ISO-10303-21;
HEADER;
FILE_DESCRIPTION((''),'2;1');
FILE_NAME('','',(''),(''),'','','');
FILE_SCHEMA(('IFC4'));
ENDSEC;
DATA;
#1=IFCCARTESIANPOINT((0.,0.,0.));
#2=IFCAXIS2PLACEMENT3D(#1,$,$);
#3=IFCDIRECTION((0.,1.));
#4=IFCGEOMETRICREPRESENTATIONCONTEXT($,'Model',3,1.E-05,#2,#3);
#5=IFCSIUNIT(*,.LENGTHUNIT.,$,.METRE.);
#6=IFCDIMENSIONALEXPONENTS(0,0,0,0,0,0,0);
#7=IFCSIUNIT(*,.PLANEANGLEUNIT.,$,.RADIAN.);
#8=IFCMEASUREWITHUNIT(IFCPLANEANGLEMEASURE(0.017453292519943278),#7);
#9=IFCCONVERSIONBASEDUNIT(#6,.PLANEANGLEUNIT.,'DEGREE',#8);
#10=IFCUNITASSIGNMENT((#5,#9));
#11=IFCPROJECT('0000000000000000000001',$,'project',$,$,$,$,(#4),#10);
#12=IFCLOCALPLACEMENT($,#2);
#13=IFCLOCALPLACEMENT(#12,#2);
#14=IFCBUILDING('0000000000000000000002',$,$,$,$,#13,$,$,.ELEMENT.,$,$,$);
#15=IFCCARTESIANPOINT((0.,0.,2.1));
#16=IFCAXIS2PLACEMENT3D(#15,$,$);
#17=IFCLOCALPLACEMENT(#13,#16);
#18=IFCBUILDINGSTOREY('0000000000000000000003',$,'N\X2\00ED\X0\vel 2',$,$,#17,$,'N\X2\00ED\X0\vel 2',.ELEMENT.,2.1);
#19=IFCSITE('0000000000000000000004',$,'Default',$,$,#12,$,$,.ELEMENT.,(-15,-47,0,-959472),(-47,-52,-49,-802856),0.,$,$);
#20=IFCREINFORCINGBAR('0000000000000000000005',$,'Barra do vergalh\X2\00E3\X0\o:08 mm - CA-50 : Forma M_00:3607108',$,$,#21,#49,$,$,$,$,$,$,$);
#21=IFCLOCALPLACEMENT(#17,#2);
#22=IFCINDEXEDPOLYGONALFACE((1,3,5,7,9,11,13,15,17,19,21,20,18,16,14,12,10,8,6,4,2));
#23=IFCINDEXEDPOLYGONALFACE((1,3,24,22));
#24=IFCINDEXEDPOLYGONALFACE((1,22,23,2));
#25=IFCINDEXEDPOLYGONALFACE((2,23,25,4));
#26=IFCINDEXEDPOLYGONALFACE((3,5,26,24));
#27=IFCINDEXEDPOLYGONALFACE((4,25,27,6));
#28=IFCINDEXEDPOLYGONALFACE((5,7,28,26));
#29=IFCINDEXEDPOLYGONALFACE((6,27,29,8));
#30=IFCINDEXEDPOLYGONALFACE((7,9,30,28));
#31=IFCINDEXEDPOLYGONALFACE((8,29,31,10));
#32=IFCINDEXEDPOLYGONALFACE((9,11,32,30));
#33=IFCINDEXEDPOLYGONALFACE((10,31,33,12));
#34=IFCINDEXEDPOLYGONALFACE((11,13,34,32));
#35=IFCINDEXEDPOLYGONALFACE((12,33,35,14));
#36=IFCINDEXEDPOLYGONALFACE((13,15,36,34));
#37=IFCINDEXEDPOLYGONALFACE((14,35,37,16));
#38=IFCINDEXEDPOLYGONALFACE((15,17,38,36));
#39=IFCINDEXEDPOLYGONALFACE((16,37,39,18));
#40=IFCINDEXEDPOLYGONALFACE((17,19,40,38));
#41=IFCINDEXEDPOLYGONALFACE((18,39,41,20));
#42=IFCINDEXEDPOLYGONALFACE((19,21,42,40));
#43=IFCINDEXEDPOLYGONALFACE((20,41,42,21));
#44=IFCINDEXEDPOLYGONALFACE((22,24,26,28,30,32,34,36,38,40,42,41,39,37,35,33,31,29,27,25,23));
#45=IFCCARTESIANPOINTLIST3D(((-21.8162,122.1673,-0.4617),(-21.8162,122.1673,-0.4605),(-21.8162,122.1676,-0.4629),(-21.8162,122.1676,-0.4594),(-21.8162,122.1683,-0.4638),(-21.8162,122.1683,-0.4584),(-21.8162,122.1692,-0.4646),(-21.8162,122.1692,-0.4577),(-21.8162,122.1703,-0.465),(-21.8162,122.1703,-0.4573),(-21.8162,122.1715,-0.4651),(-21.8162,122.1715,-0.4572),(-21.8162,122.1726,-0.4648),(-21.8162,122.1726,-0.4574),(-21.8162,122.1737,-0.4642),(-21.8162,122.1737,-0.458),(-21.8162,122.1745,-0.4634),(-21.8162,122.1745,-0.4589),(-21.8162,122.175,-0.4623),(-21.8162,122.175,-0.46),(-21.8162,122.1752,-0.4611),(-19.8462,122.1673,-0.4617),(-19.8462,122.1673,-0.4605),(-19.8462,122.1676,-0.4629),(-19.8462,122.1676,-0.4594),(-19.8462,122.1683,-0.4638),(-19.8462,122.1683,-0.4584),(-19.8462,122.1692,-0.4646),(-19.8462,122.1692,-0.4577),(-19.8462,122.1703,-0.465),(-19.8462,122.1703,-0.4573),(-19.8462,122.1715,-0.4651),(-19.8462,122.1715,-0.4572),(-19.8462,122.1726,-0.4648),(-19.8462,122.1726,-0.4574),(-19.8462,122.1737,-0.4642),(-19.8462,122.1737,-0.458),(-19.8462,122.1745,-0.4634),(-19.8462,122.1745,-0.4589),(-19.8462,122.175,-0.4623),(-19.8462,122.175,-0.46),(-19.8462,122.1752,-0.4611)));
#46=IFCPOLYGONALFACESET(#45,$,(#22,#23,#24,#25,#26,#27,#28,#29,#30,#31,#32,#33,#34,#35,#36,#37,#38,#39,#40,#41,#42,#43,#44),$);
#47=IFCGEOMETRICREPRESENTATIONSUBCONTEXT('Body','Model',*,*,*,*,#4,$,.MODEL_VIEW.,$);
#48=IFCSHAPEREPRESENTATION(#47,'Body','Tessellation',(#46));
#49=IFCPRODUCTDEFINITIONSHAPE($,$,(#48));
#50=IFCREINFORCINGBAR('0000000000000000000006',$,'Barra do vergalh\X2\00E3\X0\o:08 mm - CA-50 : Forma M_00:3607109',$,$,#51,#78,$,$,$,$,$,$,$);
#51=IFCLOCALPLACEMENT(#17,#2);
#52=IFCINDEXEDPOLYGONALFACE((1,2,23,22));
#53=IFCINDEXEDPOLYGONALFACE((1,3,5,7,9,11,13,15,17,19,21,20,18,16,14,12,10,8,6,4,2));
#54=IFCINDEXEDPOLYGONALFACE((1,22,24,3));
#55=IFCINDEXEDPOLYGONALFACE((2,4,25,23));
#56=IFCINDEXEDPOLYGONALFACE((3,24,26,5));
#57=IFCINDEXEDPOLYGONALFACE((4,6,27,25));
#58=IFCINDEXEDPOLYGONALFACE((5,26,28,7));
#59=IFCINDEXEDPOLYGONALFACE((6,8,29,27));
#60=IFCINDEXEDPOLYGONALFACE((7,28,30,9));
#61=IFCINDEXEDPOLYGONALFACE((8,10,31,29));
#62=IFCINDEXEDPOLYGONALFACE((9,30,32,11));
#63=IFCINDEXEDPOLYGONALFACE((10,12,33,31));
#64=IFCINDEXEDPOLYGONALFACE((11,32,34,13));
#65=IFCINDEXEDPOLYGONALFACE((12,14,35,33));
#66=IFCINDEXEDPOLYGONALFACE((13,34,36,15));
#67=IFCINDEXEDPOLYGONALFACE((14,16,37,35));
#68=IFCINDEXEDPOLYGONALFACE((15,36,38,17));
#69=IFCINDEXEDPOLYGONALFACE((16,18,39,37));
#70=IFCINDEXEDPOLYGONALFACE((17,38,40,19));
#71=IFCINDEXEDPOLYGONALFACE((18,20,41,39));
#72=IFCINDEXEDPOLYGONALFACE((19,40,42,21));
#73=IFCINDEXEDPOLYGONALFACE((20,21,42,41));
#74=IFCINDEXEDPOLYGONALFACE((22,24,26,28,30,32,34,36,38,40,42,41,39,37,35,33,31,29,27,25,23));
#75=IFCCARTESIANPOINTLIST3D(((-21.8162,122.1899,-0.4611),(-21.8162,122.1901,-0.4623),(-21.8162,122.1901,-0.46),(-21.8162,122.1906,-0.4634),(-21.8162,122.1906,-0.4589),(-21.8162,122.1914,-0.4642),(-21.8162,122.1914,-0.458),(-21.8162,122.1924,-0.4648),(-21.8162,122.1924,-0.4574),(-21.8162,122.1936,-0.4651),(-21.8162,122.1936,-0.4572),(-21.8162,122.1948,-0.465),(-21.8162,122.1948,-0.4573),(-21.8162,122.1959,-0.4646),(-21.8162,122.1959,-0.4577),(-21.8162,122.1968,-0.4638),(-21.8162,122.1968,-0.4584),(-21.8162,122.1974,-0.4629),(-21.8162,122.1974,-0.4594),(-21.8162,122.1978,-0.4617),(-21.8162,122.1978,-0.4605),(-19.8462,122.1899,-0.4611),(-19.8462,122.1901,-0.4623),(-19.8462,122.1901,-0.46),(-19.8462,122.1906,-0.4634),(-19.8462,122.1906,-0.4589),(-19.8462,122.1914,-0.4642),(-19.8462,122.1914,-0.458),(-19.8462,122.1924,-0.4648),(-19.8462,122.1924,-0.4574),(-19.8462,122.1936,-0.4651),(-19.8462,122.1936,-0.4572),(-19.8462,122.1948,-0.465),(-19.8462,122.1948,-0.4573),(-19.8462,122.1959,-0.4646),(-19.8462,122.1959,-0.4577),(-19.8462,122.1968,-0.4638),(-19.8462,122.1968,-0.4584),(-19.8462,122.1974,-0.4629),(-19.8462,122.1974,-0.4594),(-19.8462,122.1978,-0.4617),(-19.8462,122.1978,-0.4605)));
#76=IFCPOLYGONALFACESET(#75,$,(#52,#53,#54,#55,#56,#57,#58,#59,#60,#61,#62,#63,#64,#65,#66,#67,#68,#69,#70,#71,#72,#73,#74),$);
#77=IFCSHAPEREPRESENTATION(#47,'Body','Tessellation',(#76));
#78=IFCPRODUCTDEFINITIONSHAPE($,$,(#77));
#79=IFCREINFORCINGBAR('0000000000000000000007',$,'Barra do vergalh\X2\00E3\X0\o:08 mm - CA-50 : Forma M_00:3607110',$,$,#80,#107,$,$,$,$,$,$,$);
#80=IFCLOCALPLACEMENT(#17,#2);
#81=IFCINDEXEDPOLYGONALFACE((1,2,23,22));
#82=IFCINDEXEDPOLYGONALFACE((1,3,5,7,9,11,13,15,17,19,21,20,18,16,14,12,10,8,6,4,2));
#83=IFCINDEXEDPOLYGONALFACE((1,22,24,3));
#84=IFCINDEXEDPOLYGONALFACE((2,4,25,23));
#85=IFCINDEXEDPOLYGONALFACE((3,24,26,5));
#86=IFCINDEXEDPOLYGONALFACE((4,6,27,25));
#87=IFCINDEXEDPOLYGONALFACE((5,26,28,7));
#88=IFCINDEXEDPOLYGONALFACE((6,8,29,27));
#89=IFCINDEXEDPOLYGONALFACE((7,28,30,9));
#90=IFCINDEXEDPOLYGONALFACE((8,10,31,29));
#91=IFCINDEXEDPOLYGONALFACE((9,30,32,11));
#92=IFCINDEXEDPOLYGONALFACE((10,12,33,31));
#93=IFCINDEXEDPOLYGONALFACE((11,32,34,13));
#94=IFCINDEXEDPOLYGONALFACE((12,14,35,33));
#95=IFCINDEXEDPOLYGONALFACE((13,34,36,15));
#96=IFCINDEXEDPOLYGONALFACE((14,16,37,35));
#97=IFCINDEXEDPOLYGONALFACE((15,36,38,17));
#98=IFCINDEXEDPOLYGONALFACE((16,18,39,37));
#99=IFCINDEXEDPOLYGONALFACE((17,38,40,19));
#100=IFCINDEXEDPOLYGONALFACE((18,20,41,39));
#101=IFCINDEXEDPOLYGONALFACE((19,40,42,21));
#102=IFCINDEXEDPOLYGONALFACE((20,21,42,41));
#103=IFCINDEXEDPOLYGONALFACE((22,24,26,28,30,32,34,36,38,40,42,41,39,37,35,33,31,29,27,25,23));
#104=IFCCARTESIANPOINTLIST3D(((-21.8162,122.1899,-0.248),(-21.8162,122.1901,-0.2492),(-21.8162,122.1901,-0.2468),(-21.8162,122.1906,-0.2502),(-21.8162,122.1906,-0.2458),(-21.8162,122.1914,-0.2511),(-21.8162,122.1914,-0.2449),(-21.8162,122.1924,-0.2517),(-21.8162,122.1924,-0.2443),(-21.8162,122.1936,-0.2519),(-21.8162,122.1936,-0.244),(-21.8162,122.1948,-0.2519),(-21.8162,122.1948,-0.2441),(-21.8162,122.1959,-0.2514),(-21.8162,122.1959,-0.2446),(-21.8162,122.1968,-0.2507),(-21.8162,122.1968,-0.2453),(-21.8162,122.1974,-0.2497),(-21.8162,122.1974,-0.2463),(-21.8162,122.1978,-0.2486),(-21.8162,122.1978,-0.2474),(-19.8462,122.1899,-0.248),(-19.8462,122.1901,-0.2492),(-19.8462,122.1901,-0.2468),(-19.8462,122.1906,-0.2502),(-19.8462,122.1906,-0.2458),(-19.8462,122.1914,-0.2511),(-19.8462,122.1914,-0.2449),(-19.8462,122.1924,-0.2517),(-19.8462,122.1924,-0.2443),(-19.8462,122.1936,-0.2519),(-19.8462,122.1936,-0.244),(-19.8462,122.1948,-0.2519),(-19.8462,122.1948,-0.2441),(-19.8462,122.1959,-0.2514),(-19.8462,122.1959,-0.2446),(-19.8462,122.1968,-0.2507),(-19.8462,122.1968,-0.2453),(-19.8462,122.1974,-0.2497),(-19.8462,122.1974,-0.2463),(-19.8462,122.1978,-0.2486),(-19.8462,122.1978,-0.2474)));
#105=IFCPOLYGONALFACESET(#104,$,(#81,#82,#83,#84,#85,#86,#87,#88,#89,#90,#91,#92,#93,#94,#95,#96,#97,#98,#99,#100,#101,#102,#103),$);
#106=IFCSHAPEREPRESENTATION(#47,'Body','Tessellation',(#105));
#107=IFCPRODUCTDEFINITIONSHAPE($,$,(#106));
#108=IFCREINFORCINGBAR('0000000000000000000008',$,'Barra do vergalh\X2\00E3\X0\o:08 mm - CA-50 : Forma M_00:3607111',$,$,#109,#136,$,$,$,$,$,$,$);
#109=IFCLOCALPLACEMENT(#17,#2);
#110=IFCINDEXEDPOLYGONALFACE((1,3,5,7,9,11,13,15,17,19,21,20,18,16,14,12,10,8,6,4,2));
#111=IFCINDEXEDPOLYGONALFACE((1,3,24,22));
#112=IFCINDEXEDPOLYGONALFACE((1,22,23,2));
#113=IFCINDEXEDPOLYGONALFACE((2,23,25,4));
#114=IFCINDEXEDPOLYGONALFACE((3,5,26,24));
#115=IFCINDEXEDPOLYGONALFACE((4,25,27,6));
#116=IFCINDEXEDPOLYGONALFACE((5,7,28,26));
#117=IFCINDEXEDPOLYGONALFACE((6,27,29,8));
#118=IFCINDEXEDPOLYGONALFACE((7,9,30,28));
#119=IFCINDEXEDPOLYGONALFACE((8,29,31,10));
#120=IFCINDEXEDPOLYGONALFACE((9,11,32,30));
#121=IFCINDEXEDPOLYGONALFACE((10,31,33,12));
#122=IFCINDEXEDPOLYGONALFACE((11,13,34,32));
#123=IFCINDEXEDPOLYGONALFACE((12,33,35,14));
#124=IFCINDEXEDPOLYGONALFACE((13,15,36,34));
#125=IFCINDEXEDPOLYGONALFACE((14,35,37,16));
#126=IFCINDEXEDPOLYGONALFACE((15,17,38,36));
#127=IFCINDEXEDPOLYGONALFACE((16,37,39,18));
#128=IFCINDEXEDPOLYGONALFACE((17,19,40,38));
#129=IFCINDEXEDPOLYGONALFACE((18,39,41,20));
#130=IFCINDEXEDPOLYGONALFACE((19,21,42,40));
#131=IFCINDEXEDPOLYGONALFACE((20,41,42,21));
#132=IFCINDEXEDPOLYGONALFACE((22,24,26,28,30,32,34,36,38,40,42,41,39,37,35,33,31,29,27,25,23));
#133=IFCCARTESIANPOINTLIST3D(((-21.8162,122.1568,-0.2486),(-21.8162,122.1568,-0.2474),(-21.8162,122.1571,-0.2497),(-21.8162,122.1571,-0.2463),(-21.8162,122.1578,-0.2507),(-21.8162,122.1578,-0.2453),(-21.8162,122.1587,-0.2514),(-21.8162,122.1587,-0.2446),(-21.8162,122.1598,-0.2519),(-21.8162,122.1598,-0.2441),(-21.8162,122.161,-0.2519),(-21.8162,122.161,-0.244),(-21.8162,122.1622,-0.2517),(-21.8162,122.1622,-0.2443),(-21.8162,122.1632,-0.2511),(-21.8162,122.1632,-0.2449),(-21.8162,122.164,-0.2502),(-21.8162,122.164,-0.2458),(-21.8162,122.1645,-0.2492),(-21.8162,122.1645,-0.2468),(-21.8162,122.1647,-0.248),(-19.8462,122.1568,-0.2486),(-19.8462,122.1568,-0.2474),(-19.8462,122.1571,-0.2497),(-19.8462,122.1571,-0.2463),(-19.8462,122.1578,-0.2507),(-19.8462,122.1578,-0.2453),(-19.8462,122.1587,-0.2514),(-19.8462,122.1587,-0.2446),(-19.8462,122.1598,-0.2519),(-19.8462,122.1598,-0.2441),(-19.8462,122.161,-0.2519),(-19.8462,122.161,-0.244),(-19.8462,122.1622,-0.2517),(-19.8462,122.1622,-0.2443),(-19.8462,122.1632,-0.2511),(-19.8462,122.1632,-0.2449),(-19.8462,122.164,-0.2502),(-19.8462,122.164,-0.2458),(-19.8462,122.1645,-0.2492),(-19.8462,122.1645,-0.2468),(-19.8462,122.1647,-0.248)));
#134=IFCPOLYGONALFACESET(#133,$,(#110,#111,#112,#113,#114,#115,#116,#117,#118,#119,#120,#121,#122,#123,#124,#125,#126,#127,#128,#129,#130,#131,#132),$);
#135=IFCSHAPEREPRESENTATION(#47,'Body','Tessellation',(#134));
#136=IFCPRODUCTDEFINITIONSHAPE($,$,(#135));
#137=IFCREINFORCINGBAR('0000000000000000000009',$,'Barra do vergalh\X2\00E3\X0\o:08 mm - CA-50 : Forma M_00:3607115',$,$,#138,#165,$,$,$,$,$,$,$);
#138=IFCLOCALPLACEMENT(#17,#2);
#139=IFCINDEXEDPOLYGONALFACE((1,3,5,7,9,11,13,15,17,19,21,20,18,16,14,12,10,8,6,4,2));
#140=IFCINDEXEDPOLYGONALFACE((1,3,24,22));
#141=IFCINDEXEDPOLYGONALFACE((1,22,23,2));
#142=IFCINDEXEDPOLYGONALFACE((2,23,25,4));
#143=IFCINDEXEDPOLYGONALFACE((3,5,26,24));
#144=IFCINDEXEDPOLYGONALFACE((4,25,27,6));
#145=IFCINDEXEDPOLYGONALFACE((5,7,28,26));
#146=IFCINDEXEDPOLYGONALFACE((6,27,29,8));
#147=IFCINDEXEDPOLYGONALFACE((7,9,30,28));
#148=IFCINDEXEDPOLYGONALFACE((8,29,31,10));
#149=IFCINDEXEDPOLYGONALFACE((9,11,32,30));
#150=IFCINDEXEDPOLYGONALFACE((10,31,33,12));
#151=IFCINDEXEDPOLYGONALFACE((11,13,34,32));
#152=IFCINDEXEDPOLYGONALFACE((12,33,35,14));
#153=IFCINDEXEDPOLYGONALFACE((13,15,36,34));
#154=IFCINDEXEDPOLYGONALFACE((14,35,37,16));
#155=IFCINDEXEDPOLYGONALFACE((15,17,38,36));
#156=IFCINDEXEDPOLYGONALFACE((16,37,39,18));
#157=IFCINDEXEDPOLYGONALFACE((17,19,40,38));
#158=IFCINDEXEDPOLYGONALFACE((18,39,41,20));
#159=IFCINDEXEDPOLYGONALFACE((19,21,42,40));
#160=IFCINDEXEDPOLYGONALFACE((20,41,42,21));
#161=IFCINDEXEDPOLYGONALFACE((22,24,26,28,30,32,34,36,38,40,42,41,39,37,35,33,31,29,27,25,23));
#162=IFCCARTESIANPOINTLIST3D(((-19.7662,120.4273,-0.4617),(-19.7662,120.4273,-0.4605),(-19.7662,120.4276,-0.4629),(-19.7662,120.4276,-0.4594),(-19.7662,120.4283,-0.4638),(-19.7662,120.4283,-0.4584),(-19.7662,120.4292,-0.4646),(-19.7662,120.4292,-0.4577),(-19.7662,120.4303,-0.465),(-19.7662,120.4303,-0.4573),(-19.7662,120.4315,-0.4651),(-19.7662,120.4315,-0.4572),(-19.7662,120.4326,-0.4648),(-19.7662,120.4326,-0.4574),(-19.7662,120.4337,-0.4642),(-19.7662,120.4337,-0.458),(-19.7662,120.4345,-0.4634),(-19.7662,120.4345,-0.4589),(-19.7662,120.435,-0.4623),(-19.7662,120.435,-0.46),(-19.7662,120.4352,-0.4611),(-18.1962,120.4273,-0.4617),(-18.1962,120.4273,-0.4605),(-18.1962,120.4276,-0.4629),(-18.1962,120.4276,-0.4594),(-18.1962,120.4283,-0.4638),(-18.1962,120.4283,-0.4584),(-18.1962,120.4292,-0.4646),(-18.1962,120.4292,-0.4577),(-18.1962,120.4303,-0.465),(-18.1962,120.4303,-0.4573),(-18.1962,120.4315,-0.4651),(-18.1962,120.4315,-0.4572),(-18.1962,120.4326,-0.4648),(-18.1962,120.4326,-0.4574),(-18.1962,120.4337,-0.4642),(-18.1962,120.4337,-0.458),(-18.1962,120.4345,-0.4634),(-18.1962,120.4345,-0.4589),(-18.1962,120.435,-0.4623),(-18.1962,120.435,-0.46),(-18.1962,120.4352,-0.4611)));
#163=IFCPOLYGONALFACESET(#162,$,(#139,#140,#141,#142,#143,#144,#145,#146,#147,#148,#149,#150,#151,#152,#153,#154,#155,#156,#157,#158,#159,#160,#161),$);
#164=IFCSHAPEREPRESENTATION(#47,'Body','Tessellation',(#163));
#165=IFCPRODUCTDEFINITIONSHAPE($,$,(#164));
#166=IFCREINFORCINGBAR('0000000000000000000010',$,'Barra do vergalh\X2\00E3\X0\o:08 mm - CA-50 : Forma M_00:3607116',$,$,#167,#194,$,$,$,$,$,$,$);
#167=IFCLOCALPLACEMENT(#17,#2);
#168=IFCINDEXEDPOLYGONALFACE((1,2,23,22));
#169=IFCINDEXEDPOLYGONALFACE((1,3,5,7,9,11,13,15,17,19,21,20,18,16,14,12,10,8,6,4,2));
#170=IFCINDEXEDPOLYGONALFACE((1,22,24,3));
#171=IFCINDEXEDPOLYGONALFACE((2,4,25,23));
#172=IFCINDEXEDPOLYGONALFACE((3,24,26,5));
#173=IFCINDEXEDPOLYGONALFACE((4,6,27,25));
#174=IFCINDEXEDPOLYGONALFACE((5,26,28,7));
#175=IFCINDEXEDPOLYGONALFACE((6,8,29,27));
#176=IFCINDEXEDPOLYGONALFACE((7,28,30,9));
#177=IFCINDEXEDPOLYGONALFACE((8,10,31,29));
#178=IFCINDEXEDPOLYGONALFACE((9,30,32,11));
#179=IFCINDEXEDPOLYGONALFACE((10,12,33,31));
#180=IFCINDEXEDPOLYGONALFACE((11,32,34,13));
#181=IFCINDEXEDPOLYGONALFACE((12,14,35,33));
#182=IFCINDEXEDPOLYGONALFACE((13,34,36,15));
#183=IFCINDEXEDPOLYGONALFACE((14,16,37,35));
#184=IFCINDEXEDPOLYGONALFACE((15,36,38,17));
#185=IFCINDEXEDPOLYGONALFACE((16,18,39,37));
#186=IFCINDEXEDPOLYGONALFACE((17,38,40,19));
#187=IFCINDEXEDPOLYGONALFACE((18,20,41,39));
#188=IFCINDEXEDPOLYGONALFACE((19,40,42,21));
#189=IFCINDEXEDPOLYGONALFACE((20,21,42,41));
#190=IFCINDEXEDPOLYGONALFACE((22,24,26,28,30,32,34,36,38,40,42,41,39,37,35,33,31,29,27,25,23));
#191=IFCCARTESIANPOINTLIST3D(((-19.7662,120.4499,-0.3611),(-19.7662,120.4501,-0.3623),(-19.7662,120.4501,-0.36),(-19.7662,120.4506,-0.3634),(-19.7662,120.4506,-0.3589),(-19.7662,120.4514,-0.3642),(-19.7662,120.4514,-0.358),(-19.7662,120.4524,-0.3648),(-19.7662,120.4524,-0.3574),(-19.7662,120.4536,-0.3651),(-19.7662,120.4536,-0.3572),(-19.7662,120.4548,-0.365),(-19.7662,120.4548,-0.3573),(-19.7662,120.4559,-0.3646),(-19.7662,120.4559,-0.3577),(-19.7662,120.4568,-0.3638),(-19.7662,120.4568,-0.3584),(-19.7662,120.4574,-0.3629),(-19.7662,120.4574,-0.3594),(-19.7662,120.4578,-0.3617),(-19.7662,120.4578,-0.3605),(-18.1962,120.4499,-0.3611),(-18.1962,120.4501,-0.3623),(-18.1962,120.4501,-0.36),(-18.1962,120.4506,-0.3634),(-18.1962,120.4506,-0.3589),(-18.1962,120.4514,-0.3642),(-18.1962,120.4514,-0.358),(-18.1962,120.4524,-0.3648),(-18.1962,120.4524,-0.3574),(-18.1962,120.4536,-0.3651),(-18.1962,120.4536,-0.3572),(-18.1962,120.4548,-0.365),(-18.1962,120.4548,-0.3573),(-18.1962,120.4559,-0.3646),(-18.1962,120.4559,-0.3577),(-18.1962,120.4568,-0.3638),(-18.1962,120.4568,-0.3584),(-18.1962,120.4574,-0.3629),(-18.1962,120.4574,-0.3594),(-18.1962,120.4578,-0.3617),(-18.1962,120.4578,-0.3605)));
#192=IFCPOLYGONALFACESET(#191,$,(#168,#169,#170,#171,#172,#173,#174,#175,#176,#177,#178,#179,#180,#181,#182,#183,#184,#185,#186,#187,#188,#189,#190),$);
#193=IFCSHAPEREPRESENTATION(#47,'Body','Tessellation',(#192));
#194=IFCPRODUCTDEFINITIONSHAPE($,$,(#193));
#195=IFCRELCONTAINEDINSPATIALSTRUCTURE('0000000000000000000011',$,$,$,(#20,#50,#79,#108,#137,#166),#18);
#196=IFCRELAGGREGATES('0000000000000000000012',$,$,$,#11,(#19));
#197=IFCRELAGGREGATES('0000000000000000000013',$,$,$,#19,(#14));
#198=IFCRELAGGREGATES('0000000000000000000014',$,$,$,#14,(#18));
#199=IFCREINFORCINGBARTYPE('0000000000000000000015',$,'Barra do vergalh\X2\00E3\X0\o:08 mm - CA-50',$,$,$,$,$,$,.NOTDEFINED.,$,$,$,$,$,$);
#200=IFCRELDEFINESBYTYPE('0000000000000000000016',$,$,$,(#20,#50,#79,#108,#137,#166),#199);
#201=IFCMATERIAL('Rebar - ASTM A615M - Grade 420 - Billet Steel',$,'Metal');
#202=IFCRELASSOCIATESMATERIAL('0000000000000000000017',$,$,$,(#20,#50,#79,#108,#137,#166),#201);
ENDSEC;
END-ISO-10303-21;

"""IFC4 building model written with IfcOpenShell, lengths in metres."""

from ifc_helpers import new_model, entity, si_unit, converted_unit, direction, frame, origin, place, context, subcontext, project, spatial, material, type_object, element, save


model = new_model("IFC4")

# Units and contexts
model_context = context("Model", 3, precision=1e-05, world=origin(), true_north=direction((0.0, 1.0)))
body_context = subcontext(model_context, "Body", "Model", "MODEL_VIEW")
ifc_project = project(units=[si_unit("LENGTHUNIT", "METRE"), converted_unit("PLANEANGLEUNIT", "DEGREE", entity("IfcPlaneAngleMeasure", 0.017453292519943278), si_unit("PLANEANGLEUNIT", "RADIAN"), dimensions=[0, 0, 0, 0, 0, 0, 0])], contexts=[model_context])

# Site, building, storey
site_placement = place(None, origin())
site = spatial("IfcSite", under=ifc_project, at=site_placement, Name="Default", CompositionType="ELEMENT", RefLatitude=(-15, -47, 0, -959472), RefLongitude=(-47, -52, -49, -802856), RefElevation=0.0)
building_placement = place(site_placement, origin())
building = spatial("IfcBuilding", under=site, at=building_placement, CompositionType="ELEMENT")
storey_placement = place(building_placement, frame((0.0, 0.0, 2.1)))
storey = spatial("IfcBuildingStorey", under=building, at=storey_placement, Name="Nível 2", LongName="Nível 2", CompositionType="ELEMENT", Elevation=2.1)

# Reinforcing bars
ifc_material = material(Name="Rebar - ASTM A615M - Grade 420 - Billet Steel", Category="Metal")
reinforcing_bar_type_1 = type_object("IfcReinforcingBarType", Name="Barra do vergalhão:08 mm - CA-50", PredefinedType="NOTDEFINED")
reinforcing_bar_1_placement = place(storey_placement, origin())
element("IfcReinforcingBar", 1, at=reinforcing_bar_1_placement, inside=storey, type_object=reinforcing_bar_type_1, material=ifc_material, Name="Barra do vergalhão:08 mm - CA-50 : Forma M_00:3607108", context=body_context, shape_type="AdvancedSweptSolid", body=[
    entity("IfcSweptDiskSolid", entity("IfcIndexedPolyCurve", entity("IfcCartesianPointList3D", [[19.8462, -122.1712, 0.4611], [21.8162, -122.1712, 0.4611]]), None, False), 0.004, None, 0.0, 1.0),
])
reinforcing_bar_2_placement = place(storey_placement, origin())
element("IfcReinforcingBar", 2, at=reinforcing_bar_2_placement, inside=storey, type_object=reinforcing_bar_type_1, material=ifc_material, Name="Barra do vergalhão:08 mm - CA-50 : Forma M_00:3607109", context=body_context, shape_type="AdvancedSweptSolid", body=[
    entity("IfcSweptDiskSolid", entity("IfcIndexedPolyCurve", entity("IfcCartesianPointList3D", [[21.8162, -122.1939, 0.4611], [19.8462, -122.1939, 0.4611]]), None, False), 0.004, None, 0.0, 1.0),
])
reinforcing_bar_3_placement = place(storey_placement, origin())
element("IfcReinforcingBar", 3, at=reinforcing_bar_3_placement, inside=storey, type_object=reinforcing_bar_type_1, material=ifc_material, Name="Barra do vergalhão:08 mm - CA-50 : Forma M_00:3607110", context=body_context, shape_type="AdvancedSweptSolid", body=[
    entity("IfcSweptDiskSolid", entity("IfcIndexedPolyCurve", entity("IfcCartesianPointList3D", [[21.8162, -122.1939, 0.248], [19.8462, -122.1939, 0.248]]), None, False), 0.004, None, 0.0, 1.0),
])
reinforcing_bar_4_placement = place(storey_placement, origin())
element("IfcReinforcingBar", 4, at=reinforcing_bar_4_placement, inside=storey, type_object=reinforcing_bar_type_1, material=ifc_material, Name="Barra do vergalhão:08 mm - CA-50 : Forma M_00:3607111", context=body_context, shape_type="AdvancedSweptSolid", body=[
    entity("IfcSweptDiskSolid", entity("IfcIndexedPolyCurve", entity("IfcCartesianPointList3D", [[19.8462, -122.1607, 0.248], [21.8162, -122.1607, 0.248]]), None, False), 0.004, None, 0.0, 1.0),
])
reinforcing_bar_5_placement = place(storey_placement, origin())
element("IfcReinforcingBar", 5, at=reinforcing_bar_5_placement, inside=storey, type_object=reinforcing_bar_type_1, material=ifc_material, Name="Barra do vergalhão:08 mm - CA-50 : Forma M_00:3607115", context=body_context, shape_type="AdvancedSweptSolid", body=[
    entity("IfcSweptDiskSolid", entity("IfcIndexedPolyCurve", entity("IfcCartesianPointList3D", [[18.1962, -120.4312, 0.4611], [19.7662, -120.4312, 0.4611]]), None, False), 0.004, None, 0.0, 1.0),
])
reinforcing_bar_6_placement = place(storey_placement, origin())
element("IfcReinforcingBar", 6, at=reinforcing_bar_6_placement, inside=storey, type_object=reinforcing_bar_type_1, material=ifc_material, Name="Barra do vergalhão:08 mm - CA-50 : Forma M_00:3607116", context=body_context, shape_type="AdvancedSweptSolid", body=[
    entity("IfcSweptDiskSolid", entity("IfcIndexedPolyCurve", entity("IfcCartesianPointList3D", [[19.7662, -120.4539, 0.3611], [18.1962, -120.4539, 0.3611]]), None, False), 0.004, None, 0.0, 1.0),
])

save(model, "model.ifc")
